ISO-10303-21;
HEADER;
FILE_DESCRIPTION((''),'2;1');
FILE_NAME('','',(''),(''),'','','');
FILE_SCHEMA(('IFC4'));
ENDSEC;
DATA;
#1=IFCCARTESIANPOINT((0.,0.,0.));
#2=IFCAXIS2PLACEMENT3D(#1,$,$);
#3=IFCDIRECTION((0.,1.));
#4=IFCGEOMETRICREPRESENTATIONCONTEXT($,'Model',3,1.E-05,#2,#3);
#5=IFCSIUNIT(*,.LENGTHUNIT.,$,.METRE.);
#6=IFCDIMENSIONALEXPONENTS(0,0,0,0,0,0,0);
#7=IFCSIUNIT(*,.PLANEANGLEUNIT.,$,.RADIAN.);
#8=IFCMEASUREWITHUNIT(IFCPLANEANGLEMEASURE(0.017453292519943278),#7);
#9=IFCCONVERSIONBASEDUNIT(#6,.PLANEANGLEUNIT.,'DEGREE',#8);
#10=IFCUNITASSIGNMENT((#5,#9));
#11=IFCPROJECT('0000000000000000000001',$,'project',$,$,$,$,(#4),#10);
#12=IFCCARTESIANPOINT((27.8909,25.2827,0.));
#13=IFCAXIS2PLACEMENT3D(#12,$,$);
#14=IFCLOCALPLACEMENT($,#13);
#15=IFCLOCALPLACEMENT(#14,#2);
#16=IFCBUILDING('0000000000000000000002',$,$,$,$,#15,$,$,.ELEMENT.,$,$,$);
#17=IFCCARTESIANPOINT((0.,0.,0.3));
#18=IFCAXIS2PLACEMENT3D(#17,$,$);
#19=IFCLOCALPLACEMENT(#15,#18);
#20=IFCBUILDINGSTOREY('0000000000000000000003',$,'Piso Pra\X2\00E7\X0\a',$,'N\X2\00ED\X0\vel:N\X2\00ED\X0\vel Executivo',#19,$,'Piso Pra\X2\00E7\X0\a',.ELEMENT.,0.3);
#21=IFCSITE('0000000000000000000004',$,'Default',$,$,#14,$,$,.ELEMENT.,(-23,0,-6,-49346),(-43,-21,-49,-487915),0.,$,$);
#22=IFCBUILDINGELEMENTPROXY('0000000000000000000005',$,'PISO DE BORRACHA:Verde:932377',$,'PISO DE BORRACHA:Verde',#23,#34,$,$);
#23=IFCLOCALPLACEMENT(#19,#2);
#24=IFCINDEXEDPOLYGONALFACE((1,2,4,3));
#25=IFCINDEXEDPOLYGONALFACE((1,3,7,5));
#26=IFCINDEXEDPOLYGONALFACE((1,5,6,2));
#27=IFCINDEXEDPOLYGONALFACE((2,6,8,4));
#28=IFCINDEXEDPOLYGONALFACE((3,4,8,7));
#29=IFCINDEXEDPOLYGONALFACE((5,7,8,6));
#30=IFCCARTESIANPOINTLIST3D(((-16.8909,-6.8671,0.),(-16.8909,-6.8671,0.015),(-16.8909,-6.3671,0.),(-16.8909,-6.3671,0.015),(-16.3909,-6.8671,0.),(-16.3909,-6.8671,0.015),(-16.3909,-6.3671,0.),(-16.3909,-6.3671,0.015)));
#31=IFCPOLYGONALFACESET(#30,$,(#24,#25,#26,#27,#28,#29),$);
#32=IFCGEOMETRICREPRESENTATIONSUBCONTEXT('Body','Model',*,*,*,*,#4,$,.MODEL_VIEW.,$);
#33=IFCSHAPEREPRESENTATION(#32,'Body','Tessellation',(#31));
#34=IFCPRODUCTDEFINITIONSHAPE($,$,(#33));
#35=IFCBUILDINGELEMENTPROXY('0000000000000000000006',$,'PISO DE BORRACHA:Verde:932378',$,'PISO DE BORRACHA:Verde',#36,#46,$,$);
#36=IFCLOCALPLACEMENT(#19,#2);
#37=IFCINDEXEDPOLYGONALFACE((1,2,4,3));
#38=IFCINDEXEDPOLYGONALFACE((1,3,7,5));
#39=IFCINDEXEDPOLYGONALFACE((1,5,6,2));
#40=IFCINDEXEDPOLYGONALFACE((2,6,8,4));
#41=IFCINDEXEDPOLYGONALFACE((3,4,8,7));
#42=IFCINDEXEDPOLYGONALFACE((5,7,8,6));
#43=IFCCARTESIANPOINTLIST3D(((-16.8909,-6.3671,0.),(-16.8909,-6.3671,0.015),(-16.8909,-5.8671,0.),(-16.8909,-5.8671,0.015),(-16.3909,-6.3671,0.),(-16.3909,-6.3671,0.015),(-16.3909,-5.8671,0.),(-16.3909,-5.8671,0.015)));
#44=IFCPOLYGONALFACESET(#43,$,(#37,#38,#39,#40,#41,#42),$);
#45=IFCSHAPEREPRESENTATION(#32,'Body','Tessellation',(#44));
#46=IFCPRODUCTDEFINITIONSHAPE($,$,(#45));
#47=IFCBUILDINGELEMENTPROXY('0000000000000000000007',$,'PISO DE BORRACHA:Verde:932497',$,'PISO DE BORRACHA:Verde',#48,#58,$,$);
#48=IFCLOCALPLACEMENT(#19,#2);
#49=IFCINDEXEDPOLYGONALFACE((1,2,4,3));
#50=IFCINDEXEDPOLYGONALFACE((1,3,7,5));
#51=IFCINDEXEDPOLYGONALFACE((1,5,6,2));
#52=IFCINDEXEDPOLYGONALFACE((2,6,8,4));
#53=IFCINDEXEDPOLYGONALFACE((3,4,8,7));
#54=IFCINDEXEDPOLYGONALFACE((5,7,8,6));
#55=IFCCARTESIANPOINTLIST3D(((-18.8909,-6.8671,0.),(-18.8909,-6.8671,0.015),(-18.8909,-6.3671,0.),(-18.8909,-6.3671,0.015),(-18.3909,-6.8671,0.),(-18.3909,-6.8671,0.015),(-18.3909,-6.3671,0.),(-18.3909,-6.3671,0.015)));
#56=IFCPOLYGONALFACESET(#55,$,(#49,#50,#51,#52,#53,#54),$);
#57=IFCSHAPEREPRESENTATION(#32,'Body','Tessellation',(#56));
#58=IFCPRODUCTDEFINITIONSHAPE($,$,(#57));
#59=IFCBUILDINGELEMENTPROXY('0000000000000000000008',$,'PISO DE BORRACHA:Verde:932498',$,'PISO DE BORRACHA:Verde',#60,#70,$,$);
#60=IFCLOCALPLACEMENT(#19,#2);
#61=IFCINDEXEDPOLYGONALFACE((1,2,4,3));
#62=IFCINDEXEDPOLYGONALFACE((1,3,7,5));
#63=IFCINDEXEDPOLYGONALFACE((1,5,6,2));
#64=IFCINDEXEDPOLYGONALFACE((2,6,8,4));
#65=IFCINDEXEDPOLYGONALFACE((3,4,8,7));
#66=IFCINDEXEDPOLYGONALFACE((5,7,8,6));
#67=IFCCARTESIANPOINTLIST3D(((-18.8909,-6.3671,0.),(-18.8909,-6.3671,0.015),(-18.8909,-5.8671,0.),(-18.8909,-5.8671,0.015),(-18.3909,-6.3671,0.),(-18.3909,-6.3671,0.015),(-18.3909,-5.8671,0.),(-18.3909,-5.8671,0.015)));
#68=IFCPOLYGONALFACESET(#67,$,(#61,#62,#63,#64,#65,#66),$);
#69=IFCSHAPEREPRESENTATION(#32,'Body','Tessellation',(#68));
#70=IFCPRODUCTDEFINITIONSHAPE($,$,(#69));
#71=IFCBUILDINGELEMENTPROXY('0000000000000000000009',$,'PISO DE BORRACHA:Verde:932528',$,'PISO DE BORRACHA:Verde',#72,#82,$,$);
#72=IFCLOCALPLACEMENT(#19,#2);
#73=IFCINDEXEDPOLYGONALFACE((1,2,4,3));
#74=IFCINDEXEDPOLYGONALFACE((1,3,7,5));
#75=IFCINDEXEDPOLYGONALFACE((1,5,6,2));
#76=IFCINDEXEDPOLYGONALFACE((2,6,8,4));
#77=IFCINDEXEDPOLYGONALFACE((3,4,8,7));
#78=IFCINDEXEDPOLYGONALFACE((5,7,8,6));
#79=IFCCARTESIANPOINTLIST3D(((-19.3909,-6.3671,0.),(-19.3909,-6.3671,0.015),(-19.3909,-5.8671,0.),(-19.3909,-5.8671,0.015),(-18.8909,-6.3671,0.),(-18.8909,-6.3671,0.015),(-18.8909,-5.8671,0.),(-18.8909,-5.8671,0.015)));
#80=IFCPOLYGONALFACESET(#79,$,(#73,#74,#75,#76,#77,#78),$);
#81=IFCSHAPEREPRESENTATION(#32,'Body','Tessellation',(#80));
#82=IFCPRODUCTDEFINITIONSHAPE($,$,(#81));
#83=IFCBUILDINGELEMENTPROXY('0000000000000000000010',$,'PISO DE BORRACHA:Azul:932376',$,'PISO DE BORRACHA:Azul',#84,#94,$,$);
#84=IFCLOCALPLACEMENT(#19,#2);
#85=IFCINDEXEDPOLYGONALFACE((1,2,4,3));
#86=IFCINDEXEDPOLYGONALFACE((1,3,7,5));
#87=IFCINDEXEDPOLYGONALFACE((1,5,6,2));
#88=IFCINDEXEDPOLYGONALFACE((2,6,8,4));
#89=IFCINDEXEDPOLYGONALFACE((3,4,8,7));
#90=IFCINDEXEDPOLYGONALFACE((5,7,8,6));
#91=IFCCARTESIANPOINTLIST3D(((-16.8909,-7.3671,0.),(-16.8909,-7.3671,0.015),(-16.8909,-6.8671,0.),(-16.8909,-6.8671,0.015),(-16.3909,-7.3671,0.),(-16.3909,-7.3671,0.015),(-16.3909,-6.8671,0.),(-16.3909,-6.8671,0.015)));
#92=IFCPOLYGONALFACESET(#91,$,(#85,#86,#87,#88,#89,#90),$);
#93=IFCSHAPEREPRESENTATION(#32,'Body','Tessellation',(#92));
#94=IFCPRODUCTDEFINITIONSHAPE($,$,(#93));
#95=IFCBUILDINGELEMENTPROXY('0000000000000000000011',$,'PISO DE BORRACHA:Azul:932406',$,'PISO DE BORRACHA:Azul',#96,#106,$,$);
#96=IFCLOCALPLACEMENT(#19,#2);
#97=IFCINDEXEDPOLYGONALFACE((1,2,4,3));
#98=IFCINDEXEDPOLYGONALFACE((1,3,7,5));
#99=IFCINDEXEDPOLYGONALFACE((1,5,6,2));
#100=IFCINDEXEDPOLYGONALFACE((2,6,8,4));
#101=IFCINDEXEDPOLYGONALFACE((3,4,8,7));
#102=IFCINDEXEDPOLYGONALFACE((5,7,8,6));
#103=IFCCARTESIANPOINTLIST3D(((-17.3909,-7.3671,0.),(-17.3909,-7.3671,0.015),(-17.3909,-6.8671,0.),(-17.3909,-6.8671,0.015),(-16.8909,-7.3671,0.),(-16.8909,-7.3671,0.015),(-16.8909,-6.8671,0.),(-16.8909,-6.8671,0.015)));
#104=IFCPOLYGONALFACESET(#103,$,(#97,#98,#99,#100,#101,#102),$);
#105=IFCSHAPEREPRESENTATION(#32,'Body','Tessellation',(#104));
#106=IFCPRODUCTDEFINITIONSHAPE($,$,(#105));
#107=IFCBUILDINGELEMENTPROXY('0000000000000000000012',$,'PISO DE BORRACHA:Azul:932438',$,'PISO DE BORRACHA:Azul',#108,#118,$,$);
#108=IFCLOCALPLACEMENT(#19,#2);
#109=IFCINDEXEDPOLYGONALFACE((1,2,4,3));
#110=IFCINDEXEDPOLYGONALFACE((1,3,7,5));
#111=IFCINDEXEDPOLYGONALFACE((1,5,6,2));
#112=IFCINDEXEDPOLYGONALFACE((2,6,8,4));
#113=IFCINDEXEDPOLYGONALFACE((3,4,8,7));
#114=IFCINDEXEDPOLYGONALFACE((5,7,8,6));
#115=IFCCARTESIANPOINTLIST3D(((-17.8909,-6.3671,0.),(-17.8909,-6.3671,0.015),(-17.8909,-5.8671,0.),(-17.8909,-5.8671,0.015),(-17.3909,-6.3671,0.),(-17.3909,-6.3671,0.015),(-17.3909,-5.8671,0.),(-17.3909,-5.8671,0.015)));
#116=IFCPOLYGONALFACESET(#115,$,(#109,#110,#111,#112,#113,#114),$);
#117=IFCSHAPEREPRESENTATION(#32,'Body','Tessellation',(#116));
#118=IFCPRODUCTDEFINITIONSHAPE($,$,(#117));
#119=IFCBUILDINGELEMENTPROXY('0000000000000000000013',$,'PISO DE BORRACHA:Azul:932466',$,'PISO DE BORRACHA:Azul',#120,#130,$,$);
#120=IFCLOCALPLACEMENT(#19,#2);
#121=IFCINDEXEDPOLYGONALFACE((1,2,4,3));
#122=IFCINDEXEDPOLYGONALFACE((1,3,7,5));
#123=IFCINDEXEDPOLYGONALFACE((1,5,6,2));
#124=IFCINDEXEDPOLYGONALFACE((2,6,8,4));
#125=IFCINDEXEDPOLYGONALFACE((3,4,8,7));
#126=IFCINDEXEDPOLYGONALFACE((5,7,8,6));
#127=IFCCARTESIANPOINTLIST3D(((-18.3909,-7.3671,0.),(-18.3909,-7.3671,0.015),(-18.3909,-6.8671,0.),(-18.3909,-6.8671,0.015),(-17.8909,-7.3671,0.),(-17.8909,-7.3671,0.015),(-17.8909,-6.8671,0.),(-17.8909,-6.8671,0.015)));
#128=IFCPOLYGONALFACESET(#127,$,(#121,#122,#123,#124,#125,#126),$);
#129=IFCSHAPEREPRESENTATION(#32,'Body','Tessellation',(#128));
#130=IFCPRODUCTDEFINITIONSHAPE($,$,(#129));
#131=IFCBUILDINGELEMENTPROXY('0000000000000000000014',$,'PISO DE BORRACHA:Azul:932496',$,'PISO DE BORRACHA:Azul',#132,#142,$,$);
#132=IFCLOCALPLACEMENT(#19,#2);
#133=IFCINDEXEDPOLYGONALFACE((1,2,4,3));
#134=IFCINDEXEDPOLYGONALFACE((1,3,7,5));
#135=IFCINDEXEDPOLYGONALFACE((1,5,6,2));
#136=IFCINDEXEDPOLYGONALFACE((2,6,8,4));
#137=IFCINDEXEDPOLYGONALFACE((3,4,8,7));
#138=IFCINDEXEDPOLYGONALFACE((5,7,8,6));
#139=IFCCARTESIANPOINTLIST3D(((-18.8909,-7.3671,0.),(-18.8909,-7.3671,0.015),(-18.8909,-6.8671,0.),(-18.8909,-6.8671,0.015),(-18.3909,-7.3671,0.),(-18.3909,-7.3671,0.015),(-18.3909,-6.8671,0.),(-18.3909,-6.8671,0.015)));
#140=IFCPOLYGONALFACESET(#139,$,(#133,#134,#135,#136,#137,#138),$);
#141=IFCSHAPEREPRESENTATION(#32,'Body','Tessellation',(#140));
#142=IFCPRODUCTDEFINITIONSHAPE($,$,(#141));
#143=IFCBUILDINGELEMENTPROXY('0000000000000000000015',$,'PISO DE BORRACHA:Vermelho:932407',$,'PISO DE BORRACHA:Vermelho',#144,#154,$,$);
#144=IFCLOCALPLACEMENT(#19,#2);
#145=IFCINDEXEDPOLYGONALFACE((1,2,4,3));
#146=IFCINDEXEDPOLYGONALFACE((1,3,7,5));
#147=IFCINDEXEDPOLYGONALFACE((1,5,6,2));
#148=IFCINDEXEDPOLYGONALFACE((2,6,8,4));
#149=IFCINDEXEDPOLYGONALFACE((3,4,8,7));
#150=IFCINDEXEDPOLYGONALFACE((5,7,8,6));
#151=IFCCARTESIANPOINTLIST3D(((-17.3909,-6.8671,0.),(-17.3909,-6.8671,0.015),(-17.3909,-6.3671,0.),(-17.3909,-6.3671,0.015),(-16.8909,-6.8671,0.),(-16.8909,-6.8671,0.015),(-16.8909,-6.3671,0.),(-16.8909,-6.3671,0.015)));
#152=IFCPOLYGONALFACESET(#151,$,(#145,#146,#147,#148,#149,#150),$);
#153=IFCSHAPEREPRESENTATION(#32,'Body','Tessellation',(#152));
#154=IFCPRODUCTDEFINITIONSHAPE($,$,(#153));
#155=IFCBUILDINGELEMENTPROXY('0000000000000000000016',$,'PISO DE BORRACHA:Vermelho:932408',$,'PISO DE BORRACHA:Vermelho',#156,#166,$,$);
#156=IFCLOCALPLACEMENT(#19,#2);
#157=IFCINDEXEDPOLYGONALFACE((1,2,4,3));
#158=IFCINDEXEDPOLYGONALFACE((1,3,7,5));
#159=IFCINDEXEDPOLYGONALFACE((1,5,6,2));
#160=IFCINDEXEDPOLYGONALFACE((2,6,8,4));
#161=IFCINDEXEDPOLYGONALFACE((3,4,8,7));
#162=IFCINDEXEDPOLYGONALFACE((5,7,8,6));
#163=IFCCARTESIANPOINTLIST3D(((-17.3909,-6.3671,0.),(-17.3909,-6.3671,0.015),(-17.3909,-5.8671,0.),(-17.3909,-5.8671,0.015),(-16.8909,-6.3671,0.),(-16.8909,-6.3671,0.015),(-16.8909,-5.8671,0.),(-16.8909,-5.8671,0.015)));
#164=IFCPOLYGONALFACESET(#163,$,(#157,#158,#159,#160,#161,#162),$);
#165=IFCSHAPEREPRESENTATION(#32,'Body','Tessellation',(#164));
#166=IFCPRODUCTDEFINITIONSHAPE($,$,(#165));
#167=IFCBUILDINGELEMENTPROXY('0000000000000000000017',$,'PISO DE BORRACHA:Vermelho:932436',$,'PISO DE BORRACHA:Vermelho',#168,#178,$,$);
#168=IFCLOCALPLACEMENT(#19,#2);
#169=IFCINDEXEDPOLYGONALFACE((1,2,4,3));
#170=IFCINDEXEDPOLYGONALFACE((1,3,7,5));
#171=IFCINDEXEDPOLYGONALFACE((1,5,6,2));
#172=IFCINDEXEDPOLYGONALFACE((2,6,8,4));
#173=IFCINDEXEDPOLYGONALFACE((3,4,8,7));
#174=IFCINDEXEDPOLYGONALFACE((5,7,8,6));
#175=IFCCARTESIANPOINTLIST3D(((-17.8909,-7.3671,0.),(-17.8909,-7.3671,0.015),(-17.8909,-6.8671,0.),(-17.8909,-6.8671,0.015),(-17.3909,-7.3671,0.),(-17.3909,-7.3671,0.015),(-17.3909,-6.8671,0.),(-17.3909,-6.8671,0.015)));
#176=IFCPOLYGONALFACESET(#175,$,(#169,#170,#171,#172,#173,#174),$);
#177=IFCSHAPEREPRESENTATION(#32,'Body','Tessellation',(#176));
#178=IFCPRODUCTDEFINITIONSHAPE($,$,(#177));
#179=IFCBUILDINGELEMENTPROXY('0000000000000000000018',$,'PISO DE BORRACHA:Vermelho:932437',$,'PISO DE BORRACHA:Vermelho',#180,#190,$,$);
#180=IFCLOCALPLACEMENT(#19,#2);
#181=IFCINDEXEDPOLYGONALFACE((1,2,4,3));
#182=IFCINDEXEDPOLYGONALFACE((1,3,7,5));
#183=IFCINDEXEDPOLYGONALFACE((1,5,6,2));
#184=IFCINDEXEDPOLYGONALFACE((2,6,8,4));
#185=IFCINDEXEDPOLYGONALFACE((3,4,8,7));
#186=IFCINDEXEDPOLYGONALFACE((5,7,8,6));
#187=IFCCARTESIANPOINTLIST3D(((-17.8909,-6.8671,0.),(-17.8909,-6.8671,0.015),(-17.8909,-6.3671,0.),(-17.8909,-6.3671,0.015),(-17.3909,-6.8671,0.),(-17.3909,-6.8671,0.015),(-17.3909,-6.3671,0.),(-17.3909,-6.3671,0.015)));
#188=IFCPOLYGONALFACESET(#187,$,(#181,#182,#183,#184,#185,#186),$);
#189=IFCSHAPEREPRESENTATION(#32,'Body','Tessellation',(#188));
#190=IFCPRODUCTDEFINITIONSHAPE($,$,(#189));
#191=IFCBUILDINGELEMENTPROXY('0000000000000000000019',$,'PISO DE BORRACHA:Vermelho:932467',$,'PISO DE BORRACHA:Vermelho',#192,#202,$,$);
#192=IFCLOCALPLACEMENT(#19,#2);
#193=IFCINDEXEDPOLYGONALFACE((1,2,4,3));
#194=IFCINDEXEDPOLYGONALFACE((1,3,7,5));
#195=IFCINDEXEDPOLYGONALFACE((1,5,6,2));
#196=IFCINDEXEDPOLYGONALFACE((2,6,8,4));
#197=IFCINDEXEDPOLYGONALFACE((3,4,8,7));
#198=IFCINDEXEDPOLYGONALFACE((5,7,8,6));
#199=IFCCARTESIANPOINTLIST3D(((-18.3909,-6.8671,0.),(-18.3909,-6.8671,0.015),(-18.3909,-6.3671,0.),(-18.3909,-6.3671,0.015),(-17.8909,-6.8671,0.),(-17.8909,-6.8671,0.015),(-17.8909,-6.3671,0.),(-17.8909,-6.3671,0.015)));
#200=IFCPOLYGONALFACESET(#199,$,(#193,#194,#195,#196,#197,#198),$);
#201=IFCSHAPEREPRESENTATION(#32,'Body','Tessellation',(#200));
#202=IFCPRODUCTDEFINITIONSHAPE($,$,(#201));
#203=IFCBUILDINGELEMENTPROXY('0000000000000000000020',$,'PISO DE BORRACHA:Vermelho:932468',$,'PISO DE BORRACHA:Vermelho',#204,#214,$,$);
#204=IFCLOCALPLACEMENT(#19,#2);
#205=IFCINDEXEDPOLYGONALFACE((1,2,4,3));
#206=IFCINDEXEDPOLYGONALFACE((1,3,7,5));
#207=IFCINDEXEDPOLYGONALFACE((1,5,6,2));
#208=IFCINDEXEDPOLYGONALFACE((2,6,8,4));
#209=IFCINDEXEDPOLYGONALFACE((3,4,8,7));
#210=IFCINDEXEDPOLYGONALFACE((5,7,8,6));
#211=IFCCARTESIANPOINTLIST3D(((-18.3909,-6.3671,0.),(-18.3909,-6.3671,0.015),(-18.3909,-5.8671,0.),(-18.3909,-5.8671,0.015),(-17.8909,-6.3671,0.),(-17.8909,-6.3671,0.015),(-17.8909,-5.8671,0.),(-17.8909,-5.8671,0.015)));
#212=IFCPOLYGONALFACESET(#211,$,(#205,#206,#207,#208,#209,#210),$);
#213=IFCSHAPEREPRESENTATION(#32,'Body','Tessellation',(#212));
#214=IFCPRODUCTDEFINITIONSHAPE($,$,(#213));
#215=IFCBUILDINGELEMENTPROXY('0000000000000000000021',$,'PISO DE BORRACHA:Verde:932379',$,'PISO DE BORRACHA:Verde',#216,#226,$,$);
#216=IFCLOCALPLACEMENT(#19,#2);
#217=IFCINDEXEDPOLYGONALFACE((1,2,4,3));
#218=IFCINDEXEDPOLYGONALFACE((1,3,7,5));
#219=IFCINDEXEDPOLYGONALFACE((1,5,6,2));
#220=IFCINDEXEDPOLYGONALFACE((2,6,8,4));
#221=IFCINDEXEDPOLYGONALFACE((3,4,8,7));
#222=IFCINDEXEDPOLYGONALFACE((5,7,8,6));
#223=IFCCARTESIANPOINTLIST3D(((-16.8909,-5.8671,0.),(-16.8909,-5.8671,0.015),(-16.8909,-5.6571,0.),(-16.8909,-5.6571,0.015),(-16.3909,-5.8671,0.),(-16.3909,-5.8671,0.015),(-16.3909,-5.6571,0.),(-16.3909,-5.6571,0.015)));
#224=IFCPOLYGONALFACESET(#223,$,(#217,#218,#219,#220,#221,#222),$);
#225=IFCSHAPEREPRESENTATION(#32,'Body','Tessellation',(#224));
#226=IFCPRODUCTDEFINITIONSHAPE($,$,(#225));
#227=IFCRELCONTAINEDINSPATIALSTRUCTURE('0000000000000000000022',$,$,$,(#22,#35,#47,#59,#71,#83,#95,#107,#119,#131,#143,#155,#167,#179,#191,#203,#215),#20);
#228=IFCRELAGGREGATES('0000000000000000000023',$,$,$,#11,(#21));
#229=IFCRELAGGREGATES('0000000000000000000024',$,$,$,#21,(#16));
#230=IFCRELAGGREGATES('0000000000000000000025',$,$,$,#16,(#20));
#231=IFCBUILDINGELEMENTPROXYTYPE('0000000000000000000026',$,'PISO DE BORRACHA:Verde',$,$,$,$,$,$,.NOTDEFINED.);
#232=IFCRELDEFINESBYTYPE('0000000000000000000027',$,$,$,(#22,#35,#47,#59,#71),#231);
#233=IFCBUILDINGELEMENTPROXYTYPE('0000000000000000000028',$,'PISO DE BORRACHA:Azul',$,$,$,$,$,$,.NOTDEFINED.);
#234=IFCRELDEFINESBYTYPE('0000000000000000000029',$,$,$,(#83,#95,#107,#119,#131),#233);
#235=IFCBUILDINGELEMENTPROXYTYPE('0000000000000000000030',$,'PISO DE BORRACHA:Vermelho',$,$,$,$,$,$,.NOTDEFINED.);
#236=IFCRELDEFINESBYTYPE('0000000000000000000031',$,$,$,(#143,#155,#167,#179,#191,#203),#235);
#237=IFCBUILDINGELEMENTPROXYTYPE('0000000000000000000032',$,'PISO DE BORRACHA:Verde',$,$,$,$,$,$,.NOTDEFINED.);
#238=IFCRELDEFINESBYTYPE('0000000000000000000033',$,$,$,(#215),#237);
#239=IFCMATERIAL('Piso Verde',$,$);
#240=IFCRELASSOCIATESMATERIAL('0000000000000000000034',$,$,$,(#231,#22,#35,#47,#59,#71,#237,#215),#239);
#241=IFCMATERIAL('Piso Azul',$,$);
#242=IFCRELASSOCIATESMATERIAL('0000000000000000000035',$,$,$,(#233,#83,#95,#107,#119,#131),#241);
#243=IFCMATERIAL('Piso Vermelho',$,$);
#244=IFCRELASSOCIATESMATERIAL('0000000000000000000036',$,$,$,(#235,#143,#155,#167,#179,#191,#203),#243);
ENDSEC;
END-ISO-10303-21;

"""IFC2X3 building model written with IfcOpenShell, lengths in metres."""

from ifc_helpers import new_model, entity, si_unit, converted_unit, direction, frame, frame_2d, origin, origin_2d_with_axis, place, context, subcontext, project, spatial, rectangle, extrude, source, transform, mapped, material, type_object, type_shapes, element, save


model = new_model("IFC2X3")

# Units and contexts
model_context = context("Model", 3, precision=1e-05, world=origin(), true_north=direction((0.0, 1.0)))
body_context = subcontext(model_context, "Body", "Model", "MODEL_VIEW")
ifc_project = project(units=[si_unit("LENGTHUNIT", "METRE"), converted_unit("PLANEANGLEUNIT", "DEGREE", entity("IfcPlaneAngleMeasure", 0.017453292519943278), si_unit("PLANEANGLEUNIT", "RADIAN"), dimensions=[0, 0, 0, 0, 0, 0, 0])], contexts=[model_context])

# Site, building, storey
site_placement = place(None, frame((27.8909, 25.2827, 0.0)))
site = spatial("IfcSite", under=ifc_project, at=site_placement, Name="Default", CompositionType="ELEMENT", RefLatitude=(-23, 0, -6, -49346), RefLongitude=(-43, -21, -49, -487915), RefElevation=0.0)
building_placement = place(site_placement, origin())
building = spatial("IfcBuilding", under=site, at=building_placement, CompositionType="ELEMENT")
storey_placement = place(building_placement, frame((0.0, 0.0, 0.3)))
storey = spatial("IfcBuildingStorey", under=building, at=storey_placement, Name="Piso Praça", ObjectType="Nível:Nível Executivo", LongName="Piso Praça", CompositionType="ELEMENT", Elevation=0.3)

# Building element proxies
ifc_material_1 = material(Name="Piso Verde")
building_element_proxy_type_1 = type_object("IfcBuildingElementProxyType", Name="PISO DE BORRACHA:Verde", PredefinedType="NOTDEFINED", material=ifc_material_1)
shared_shape_1 = source(origin(), body_context, "Body", "SweptSolid", [
    extrude(rectangle(XDim=0.5, YDim=0.5, at=origin_2d_with_axis()), frame((0.25, 0.25, 0.0), z_axis=(0.0, 0.0, 1.0), x_axis=(-1.0, 0.0, 0.0)), (0.0, 0.0, 1.0), 0.015),
])
type_shapes(building_element_proxy_type_1, [shared_shape_1])
for number, where, z_axis, x_axis, name in (
    (1, (-16.8909, -6.3671, 0.0), (0.0, 0.0, 1.0), (0.0, -1.0, 0.0), "PISO DE BORRACHA:Verde:932377"),
    (2, (-16.8909, -5.8671, 0.0), (0.0, 0.0, 1.0), (0.0, -1.0, 0.0), "PISO DE BORRACHA:Verde:932378"),
    (3, (-18.8909, -6.3671, 0.0), (0.0, 0.0, 1.0), (0.0, -1.0, 0.0), "PISO DE BORRACHA:Verde:932497"),
    (4, (-18.8909, -5.8671, 0.0), (0.0, 0.0, 1.0), (0.0, -1.0, 0.0), "PISO DE BORRACHA:Verde:932498"),
    (5, (-19.3909, -5.8671, 0.0), (0.0, 0.0, 1.0), (0.0, -1.0, 0.0), "PISO DE BORRACHA:Verde:932528"),
):
    element("IfcBuildingElementProxy", number, at=place(storey_placement, frame(where, z_axis=z_axis, x_axis=x_axis)), inside=storey, type_object=building_element_proxy_type_1, material=ifc_material_1, Name=name, ObjectType="PISO DE BORRACHA:Verde", context=body_context, shape_type="MappedRepresentation", body=[
        mapped(shared_shape_1, transform((0.0, 0.0, 0.0), scale=1.0)),
    ])
ifc_material_2 = material(Name="Piso Azul")
building_element_proxy_type_2 = type_object("IfcBuildingElementProxyType", Name="PISO DE BORRACHA:Azul", PredefinedType="NOTDEFINED", material=ifc_material_2)
shared_shape_2 = source(origin(), body_context, "Body", "SweptSolid", [
    extrude(rectangle(XDim=0.5, YDim=0.5, at=origin_2d_with_axis()), frame((0.25, 0.25, 0.0), z_axis=(0.0, 0.0, 1.0), x_axis=(-1.0, 0.0, 0.0)), (0.0, 0.0, 1.0), 0.015),
])
type_shapes(building_element_proxy_type_2, [shared_shape_2])
for number, where, z_axis, x_axis, name in (
    (6, (-16.8909, -6.8671, 0.0), (0.0, 0.0, 1.0), (0.0, -1.0, 0.0), "PISO DE BORRACHA:Azul:932376"),
    (7, (-17.3909, -6.8671, 0.0), (0.0, 0.0, 1.0), (0.0, -1.0, 0.0), "PISO DE BORRACHA:Azul:932406"),
    (8, (-17.8909, -5.8671, 0.0), (0.0, 0.0, 1.0), (0.0, -1.0, 0.0), "PISO DE BORRACHA:Azul:932438"),
    (9, (-18.3909, -6.8671, 0.0), (0.0, 0.0, 1.0), (0.0, -1.0, 0.0), "PISO DE BORRACHA:Azul:932466"),
    (10, (-18.8909, -6.8671, 0.0), (0.0, 0.0, 1.0), (0.0, -1.0, 0.0), "PISO DE BORRACHA:Azul:932496"),
):
    element("IfcBuildingElementProxy", number, at=place(storey_placement, frame(where, z_axis=z_axis, x_axis=x_axis)), inside=storey, type_object=building_element_proxy_type_2, material=ifc_material_2, Name=name, ObjectType="PISO DE BORRACHA:Azul", context=body_context, shape_type="MappedRepresentation", body=[
        mapped(shared_shape_2, transform((0.0, 0.0, 0.0), scale=1.0)),
    ])
ifc_material_3 = material(Name="Piso Vermelho")
building_element_proxy_type_3 = type_object("IfcBuildingElementProxyType", Name="PISO DE BORRACHA:Vermelho", PredefinedType="NOTDEFINED", material=ifc_material_3)
shared_shape_3 = source(origin(), body_context, "Body", "SweptSolid", [
    extrude(rectangle(XDim=0.5, YDim=0.5, at=origin_2d_with_axis()), frame((0.25, 0.25, 0.0), z_axis=(0.0, 0.0, 1.0), x_axis=(-1.0, 0.0, 0.0)), (0.0, 0.0, 1.0), 0.015),
])
type_shapes(building_element_proxy_type_3, [shared_shape_3])
for number, where, z_axis, x_axis, name in (
    (11, (-17.3909, -6.3671, 0.0), (0.0, 0.0, 1.0), (0.0, -1.0, 0.0), "PISO DE BORRACHA:Vermelho:932407"),
    (12, (-17.3909, -5.8671, 0.0), (0.0, 0.0, 1.0), (0.0, -1.0, 0.0), "PISO DE BORRACHA:Vermelho:932408"),
    (13, (-17.8909, -6.8671, 0.0), (0.0, 0.0, 1.0), (0.0, -1.0, 0.0), "PISO DE BORRACHA:Vermelho:932436"),
    (14, (-17.8909, -6.3671, 0.0), (0.0, 0.0, 1.0), (0.0, -1.0, 0.0), "PISO DE BORRACHA:Vermelho:932437"),
    (15, (-18.3909, -6.3671, 0.0), (0.0, 0.0, 1.0), (0.0, -1.0, 0.0), "PISO DE BORRACHA:Vermelho:932467"),
    (16, (-18.3909, -5.8671, 0.0), (0.0, 0.0, 1.0), (0.0, -1.0, 0.0), "PISO DE BORRACHA:Vermelho:932468"),
):
    element("IfcBuildingElementProxy", number, at=place(storey_placement, frame(where, z_axis=z_axis, x_axis=x_axis)), inside=storey, type_object=building_element_proxy_type_3, material=ifc_material_3, Name=name, ObjectType="PISO DE BORRACHA:Vermelho", context=body_context, shape_type="MappedRepresentation", body=[
        mapped(shared_shape_3, transform((0.0, 0.0, 0.0), scale=1.0)),
    ])
building_element_proxy_type_4 = type_object("IfcBuildingElementProxyType", Name="PISO DE BORRACHA:Verde", PredefinedType="NOTDEFINED", material=ifc_material_1)
shared_shape_4 = source(origin(), body_context, "Body", "SweptSolid", [
    extrude(rectangle(XDim=0.21, YDim=0.5, at=frame_2d((0.0, 0.0), x_axis=(1.0, 0.0))), frame((0.105, 0.25, 0.0), z_axis=(0.0, 0.0, 1.0), x_axis=(-1.0, 0.0, 0.0)), (0.0, 0.0, 1.0), 0.015),
])
type_shapes(building_element_proxy_type_4, [shared_shape_4])
for number, where, z_axis, x_axis, name in (
    (17, (-16.8909, -5.6571, 0.0), (0.0, 0.0, 1.0), (0.0, -1.0, 0.0), "PISO DE BORRACHA:Verde:932379"),
):
    element("IfcBuildingElementProxy", number, at=place(storey_placement, frame(where, z_axis=z_axis, x_axis=x_axis)), inside=storey, type_object=building_element_proxy_type_4, material=ifc_material_1, Name=name, ObjectType="PISO DE BORRACHA:Verde", context=body_context, shape_type="MappedRepresentation", body=[
        mapped(shared_shape_4, transform((0.0, 0.0, 0.0), scale=1.0)),
    ])

save(model, "model.ifc")
